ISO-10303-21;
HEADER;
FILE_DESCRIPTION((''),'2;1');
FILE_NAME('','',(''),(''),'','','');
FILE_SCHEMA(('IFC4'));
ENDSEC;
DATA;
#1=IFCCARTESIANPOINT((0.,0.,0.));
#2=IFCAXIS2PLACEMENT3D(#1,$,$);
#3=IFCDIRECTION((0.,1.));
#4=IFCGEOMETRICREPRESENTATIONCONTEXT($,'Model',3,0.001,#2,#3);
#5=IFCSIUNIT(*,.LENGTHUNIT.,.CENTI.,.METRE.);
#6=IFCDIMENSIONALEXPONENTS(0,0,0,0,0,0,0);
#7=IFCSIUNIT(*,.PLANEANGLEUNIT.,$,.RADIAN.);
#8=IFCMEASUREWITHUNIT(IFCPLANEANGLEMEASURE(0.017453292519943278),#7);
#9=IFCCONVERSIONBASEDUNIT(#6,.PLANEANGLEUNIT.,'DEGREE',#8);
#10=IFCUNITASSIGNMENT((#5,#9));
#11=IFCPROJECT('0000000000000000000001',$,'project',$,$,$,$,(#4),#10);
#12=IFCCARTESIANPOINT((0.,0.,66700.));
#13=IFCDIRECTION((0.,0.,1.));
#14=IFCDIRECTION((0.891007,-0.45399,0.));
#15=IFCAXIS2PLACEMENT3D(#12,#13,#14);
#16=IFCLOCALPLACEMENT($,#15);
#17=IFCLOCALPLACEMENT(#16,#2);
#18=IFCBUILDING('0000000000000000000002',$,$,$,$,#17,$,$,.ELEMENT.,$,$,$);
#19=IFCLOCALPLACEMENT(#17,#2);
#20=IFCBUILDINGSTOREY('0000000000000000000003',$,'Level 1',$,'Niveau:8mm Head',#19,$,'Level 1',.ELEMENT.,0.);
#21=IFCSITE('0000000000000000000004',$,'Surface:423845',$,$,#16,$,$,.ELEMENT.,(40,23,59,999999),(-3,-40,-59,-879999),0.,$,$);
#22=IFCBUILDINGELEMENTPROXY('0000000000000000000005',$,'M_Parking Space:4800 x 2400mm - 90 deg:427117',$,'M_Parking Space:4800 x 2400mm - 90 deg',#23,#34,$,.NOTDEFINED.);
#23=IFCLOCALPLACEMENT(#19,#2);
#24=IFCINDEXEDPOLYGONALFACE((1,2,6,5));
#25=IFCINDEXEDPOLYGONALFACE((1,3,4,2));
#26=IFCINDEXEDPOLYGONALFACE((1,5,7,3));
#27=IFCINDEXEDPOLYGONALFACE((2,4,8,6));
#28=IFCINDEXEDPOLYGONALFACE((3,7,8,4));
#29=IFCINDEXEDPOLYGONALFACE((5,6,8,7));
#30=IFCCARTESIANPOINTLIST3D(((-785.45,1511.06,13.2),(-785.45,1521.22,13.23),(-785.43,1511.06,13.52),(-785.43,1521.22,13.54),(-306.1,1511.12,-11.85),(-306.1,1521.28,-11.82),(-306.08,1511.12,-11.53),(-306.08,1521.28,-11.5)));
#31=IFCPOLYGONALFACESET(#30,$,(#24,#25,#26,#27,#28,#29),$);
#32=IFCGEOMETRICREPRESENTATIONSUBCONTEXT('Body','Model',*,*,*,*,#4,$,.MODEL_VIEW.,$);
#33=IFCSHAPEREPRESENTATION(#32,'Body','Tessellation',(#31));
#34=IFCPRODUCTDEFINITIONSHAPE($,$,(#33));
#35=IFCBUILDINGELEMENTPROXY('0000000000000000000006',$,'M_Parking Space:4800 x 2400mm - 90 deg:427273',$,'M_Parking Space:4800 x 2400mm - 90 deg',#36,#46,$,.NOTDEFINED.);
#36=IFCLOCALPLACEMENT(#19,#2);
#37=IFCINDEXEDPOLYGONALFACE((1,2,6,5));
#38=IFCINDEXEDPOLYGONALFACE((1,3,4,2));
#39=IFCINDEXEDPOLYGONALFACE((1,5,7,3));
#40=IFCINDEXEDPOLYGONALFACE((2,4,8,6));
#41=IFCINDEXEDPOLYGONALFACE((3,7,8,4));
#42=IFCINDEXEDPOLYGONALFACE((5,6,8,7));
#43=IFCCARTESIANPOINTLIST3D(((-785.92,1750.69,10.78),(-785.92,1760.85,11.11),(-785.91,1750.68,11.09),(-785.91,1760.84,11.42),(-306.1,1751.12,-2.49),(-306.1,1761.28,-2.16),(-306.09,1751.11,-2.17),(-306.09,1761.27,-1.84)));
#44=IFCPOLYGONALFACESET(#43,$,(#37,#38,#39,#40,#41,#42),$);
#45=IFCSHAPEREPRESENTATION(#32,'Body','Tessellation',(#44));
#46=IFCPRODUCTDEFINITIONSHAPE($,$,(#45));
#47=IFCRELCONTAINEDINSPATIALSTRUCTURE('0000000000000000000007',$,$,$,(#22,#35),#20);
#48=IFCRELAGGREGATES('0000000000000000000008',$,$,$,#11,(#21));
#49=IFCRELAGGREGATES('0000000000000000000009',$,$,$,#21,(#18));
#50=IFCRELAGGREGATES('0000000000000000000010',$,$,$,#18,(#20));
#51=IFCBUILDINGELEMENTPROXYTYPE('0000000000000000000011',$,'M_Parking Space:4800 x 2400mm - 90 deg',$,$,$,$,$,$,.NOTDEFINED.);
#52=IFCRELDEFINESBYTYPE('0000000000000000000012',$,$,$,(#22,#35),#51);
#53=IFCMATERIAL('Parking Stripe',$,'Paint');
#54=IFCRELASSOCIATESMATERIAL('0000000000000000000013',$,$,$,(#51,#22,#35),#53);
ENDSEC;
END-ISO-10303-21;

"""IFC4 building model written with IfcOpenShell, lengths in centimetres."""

from ifc_helpers import new_model, entity, si_unit, converted_unit, direction, frame, origin, origin_2d_with_axis, place, context, subcontext, project, spatial, rectangle, extrude, source, transform, mapped, material, type_object, type_shapes, element, save


model = new_model("IFC4")

# Units and contexts
model_context = context("Model", 3, precision=0.001, world=origin(), true_north=direction((0.0, 1.0)))
body_context = subcontext(model_context, "Body", "Model", "MODEL_VIEW")
ifc_project = project(units=[si_unit("LENGTHUNIT", "METRE", prefix="CENTI"), converted_unit("PLANEANGLEUNIT", "DEGREE", entity("IfcPlaneAngleMeasure", 0.017453292519943278), si_unit("PLANEANGLEUNIT", "RADIAN"), dimensions=[0, 0, 0, 0, 0, 0, 0])], contexts=[model_context])

# Site, building, storey
site_placement = place(None, frame((0.0, 0.0, 66700.0), z_axis=(0.0, 0.0, 1.0), x_axis=(0.891007, -0.45399, 0.0)))
site = spatial("IfcSite", under=ifc_project, at=site_placement, Name="Surface:423845", CompositionType="ELEMENT", RefLatitude=(40, 23, 59, 999999), RefLongitude=(-3, -40, -59, -879999), RefElevation=0.0)
building_placement = place(site_placement, origin())
building = spatial("IfcBuilding", under=site, at=building_placement, CompositionType="ELEMENT")
storey_placement = place(building_placement, origin())
storey = spatial("IfcBuildingStorey", under=building, at=storey_placement, Name="Level 1", ObjectType="Niveau:8mm Head", LongName="Level 1", CompositionType="ELEMENT", Elevation=0.0)

# Building element proxies
ifc_material = material(Name="Parking Stripe", Category="Paint")
building_element_proxy_type = type_object("IfcBuildingElementProxyType", Name="M_Parking Space:4800 x 2400mm - 90 deg", PredefinedType="NOTDEFINED", material=ifc_material)
shared_shape = source(origin(), body_context, "Body", "SweptSolid", [
    extrude(rectangle(XDim=480.0, YDim=10.16, at=origin_2d_with_axis()), frame((0.0, -240.0, 0.0), z_axis=(0.0, 0.0, 1.0), x_axis=(0.0, -1.0, 0.0)), (0.0, 0.0, 1.0), 0.32),
])
type_shapes(building_element_proxy_type, [shared_shape])
for number, where, z_axis, x_axis, name in (
    (1, (-306.1, 1516.2, -11.83), (0.052179, -0.002488, 0.998635), (0.0, -0.999997, -0.002491), "M_Parking Space:4800 x 2400mm - 90 deg:427117"),
    (2, (-306.1, 1756.2, -2.32), (0.027647, -0.032508, 0.999089), (0.0, -0.999471, -0.03252), "M_Parking Space:4800 x 2400mm - 90 deg:427273"),
):
    element("IfcBuildingElementProxy", number, at=place(storey_placement, frame(where, z_axis=z_axis, x_axis=x_axis)), inside=storey, type_object=building_element_proxy_type, material=ifc_material, Name=name, ObjectType="M_Parking Space:4800 x 2400mm - 90 deg", PredefinedType="NOTDEFINED", context=body_context, shape_type="MappedRepresentation", body=[
        mapped(shared_shape, transform((0.0, 0.0, 0.0), scale=1.0)),
    ])

save(model, "model.ifc")
